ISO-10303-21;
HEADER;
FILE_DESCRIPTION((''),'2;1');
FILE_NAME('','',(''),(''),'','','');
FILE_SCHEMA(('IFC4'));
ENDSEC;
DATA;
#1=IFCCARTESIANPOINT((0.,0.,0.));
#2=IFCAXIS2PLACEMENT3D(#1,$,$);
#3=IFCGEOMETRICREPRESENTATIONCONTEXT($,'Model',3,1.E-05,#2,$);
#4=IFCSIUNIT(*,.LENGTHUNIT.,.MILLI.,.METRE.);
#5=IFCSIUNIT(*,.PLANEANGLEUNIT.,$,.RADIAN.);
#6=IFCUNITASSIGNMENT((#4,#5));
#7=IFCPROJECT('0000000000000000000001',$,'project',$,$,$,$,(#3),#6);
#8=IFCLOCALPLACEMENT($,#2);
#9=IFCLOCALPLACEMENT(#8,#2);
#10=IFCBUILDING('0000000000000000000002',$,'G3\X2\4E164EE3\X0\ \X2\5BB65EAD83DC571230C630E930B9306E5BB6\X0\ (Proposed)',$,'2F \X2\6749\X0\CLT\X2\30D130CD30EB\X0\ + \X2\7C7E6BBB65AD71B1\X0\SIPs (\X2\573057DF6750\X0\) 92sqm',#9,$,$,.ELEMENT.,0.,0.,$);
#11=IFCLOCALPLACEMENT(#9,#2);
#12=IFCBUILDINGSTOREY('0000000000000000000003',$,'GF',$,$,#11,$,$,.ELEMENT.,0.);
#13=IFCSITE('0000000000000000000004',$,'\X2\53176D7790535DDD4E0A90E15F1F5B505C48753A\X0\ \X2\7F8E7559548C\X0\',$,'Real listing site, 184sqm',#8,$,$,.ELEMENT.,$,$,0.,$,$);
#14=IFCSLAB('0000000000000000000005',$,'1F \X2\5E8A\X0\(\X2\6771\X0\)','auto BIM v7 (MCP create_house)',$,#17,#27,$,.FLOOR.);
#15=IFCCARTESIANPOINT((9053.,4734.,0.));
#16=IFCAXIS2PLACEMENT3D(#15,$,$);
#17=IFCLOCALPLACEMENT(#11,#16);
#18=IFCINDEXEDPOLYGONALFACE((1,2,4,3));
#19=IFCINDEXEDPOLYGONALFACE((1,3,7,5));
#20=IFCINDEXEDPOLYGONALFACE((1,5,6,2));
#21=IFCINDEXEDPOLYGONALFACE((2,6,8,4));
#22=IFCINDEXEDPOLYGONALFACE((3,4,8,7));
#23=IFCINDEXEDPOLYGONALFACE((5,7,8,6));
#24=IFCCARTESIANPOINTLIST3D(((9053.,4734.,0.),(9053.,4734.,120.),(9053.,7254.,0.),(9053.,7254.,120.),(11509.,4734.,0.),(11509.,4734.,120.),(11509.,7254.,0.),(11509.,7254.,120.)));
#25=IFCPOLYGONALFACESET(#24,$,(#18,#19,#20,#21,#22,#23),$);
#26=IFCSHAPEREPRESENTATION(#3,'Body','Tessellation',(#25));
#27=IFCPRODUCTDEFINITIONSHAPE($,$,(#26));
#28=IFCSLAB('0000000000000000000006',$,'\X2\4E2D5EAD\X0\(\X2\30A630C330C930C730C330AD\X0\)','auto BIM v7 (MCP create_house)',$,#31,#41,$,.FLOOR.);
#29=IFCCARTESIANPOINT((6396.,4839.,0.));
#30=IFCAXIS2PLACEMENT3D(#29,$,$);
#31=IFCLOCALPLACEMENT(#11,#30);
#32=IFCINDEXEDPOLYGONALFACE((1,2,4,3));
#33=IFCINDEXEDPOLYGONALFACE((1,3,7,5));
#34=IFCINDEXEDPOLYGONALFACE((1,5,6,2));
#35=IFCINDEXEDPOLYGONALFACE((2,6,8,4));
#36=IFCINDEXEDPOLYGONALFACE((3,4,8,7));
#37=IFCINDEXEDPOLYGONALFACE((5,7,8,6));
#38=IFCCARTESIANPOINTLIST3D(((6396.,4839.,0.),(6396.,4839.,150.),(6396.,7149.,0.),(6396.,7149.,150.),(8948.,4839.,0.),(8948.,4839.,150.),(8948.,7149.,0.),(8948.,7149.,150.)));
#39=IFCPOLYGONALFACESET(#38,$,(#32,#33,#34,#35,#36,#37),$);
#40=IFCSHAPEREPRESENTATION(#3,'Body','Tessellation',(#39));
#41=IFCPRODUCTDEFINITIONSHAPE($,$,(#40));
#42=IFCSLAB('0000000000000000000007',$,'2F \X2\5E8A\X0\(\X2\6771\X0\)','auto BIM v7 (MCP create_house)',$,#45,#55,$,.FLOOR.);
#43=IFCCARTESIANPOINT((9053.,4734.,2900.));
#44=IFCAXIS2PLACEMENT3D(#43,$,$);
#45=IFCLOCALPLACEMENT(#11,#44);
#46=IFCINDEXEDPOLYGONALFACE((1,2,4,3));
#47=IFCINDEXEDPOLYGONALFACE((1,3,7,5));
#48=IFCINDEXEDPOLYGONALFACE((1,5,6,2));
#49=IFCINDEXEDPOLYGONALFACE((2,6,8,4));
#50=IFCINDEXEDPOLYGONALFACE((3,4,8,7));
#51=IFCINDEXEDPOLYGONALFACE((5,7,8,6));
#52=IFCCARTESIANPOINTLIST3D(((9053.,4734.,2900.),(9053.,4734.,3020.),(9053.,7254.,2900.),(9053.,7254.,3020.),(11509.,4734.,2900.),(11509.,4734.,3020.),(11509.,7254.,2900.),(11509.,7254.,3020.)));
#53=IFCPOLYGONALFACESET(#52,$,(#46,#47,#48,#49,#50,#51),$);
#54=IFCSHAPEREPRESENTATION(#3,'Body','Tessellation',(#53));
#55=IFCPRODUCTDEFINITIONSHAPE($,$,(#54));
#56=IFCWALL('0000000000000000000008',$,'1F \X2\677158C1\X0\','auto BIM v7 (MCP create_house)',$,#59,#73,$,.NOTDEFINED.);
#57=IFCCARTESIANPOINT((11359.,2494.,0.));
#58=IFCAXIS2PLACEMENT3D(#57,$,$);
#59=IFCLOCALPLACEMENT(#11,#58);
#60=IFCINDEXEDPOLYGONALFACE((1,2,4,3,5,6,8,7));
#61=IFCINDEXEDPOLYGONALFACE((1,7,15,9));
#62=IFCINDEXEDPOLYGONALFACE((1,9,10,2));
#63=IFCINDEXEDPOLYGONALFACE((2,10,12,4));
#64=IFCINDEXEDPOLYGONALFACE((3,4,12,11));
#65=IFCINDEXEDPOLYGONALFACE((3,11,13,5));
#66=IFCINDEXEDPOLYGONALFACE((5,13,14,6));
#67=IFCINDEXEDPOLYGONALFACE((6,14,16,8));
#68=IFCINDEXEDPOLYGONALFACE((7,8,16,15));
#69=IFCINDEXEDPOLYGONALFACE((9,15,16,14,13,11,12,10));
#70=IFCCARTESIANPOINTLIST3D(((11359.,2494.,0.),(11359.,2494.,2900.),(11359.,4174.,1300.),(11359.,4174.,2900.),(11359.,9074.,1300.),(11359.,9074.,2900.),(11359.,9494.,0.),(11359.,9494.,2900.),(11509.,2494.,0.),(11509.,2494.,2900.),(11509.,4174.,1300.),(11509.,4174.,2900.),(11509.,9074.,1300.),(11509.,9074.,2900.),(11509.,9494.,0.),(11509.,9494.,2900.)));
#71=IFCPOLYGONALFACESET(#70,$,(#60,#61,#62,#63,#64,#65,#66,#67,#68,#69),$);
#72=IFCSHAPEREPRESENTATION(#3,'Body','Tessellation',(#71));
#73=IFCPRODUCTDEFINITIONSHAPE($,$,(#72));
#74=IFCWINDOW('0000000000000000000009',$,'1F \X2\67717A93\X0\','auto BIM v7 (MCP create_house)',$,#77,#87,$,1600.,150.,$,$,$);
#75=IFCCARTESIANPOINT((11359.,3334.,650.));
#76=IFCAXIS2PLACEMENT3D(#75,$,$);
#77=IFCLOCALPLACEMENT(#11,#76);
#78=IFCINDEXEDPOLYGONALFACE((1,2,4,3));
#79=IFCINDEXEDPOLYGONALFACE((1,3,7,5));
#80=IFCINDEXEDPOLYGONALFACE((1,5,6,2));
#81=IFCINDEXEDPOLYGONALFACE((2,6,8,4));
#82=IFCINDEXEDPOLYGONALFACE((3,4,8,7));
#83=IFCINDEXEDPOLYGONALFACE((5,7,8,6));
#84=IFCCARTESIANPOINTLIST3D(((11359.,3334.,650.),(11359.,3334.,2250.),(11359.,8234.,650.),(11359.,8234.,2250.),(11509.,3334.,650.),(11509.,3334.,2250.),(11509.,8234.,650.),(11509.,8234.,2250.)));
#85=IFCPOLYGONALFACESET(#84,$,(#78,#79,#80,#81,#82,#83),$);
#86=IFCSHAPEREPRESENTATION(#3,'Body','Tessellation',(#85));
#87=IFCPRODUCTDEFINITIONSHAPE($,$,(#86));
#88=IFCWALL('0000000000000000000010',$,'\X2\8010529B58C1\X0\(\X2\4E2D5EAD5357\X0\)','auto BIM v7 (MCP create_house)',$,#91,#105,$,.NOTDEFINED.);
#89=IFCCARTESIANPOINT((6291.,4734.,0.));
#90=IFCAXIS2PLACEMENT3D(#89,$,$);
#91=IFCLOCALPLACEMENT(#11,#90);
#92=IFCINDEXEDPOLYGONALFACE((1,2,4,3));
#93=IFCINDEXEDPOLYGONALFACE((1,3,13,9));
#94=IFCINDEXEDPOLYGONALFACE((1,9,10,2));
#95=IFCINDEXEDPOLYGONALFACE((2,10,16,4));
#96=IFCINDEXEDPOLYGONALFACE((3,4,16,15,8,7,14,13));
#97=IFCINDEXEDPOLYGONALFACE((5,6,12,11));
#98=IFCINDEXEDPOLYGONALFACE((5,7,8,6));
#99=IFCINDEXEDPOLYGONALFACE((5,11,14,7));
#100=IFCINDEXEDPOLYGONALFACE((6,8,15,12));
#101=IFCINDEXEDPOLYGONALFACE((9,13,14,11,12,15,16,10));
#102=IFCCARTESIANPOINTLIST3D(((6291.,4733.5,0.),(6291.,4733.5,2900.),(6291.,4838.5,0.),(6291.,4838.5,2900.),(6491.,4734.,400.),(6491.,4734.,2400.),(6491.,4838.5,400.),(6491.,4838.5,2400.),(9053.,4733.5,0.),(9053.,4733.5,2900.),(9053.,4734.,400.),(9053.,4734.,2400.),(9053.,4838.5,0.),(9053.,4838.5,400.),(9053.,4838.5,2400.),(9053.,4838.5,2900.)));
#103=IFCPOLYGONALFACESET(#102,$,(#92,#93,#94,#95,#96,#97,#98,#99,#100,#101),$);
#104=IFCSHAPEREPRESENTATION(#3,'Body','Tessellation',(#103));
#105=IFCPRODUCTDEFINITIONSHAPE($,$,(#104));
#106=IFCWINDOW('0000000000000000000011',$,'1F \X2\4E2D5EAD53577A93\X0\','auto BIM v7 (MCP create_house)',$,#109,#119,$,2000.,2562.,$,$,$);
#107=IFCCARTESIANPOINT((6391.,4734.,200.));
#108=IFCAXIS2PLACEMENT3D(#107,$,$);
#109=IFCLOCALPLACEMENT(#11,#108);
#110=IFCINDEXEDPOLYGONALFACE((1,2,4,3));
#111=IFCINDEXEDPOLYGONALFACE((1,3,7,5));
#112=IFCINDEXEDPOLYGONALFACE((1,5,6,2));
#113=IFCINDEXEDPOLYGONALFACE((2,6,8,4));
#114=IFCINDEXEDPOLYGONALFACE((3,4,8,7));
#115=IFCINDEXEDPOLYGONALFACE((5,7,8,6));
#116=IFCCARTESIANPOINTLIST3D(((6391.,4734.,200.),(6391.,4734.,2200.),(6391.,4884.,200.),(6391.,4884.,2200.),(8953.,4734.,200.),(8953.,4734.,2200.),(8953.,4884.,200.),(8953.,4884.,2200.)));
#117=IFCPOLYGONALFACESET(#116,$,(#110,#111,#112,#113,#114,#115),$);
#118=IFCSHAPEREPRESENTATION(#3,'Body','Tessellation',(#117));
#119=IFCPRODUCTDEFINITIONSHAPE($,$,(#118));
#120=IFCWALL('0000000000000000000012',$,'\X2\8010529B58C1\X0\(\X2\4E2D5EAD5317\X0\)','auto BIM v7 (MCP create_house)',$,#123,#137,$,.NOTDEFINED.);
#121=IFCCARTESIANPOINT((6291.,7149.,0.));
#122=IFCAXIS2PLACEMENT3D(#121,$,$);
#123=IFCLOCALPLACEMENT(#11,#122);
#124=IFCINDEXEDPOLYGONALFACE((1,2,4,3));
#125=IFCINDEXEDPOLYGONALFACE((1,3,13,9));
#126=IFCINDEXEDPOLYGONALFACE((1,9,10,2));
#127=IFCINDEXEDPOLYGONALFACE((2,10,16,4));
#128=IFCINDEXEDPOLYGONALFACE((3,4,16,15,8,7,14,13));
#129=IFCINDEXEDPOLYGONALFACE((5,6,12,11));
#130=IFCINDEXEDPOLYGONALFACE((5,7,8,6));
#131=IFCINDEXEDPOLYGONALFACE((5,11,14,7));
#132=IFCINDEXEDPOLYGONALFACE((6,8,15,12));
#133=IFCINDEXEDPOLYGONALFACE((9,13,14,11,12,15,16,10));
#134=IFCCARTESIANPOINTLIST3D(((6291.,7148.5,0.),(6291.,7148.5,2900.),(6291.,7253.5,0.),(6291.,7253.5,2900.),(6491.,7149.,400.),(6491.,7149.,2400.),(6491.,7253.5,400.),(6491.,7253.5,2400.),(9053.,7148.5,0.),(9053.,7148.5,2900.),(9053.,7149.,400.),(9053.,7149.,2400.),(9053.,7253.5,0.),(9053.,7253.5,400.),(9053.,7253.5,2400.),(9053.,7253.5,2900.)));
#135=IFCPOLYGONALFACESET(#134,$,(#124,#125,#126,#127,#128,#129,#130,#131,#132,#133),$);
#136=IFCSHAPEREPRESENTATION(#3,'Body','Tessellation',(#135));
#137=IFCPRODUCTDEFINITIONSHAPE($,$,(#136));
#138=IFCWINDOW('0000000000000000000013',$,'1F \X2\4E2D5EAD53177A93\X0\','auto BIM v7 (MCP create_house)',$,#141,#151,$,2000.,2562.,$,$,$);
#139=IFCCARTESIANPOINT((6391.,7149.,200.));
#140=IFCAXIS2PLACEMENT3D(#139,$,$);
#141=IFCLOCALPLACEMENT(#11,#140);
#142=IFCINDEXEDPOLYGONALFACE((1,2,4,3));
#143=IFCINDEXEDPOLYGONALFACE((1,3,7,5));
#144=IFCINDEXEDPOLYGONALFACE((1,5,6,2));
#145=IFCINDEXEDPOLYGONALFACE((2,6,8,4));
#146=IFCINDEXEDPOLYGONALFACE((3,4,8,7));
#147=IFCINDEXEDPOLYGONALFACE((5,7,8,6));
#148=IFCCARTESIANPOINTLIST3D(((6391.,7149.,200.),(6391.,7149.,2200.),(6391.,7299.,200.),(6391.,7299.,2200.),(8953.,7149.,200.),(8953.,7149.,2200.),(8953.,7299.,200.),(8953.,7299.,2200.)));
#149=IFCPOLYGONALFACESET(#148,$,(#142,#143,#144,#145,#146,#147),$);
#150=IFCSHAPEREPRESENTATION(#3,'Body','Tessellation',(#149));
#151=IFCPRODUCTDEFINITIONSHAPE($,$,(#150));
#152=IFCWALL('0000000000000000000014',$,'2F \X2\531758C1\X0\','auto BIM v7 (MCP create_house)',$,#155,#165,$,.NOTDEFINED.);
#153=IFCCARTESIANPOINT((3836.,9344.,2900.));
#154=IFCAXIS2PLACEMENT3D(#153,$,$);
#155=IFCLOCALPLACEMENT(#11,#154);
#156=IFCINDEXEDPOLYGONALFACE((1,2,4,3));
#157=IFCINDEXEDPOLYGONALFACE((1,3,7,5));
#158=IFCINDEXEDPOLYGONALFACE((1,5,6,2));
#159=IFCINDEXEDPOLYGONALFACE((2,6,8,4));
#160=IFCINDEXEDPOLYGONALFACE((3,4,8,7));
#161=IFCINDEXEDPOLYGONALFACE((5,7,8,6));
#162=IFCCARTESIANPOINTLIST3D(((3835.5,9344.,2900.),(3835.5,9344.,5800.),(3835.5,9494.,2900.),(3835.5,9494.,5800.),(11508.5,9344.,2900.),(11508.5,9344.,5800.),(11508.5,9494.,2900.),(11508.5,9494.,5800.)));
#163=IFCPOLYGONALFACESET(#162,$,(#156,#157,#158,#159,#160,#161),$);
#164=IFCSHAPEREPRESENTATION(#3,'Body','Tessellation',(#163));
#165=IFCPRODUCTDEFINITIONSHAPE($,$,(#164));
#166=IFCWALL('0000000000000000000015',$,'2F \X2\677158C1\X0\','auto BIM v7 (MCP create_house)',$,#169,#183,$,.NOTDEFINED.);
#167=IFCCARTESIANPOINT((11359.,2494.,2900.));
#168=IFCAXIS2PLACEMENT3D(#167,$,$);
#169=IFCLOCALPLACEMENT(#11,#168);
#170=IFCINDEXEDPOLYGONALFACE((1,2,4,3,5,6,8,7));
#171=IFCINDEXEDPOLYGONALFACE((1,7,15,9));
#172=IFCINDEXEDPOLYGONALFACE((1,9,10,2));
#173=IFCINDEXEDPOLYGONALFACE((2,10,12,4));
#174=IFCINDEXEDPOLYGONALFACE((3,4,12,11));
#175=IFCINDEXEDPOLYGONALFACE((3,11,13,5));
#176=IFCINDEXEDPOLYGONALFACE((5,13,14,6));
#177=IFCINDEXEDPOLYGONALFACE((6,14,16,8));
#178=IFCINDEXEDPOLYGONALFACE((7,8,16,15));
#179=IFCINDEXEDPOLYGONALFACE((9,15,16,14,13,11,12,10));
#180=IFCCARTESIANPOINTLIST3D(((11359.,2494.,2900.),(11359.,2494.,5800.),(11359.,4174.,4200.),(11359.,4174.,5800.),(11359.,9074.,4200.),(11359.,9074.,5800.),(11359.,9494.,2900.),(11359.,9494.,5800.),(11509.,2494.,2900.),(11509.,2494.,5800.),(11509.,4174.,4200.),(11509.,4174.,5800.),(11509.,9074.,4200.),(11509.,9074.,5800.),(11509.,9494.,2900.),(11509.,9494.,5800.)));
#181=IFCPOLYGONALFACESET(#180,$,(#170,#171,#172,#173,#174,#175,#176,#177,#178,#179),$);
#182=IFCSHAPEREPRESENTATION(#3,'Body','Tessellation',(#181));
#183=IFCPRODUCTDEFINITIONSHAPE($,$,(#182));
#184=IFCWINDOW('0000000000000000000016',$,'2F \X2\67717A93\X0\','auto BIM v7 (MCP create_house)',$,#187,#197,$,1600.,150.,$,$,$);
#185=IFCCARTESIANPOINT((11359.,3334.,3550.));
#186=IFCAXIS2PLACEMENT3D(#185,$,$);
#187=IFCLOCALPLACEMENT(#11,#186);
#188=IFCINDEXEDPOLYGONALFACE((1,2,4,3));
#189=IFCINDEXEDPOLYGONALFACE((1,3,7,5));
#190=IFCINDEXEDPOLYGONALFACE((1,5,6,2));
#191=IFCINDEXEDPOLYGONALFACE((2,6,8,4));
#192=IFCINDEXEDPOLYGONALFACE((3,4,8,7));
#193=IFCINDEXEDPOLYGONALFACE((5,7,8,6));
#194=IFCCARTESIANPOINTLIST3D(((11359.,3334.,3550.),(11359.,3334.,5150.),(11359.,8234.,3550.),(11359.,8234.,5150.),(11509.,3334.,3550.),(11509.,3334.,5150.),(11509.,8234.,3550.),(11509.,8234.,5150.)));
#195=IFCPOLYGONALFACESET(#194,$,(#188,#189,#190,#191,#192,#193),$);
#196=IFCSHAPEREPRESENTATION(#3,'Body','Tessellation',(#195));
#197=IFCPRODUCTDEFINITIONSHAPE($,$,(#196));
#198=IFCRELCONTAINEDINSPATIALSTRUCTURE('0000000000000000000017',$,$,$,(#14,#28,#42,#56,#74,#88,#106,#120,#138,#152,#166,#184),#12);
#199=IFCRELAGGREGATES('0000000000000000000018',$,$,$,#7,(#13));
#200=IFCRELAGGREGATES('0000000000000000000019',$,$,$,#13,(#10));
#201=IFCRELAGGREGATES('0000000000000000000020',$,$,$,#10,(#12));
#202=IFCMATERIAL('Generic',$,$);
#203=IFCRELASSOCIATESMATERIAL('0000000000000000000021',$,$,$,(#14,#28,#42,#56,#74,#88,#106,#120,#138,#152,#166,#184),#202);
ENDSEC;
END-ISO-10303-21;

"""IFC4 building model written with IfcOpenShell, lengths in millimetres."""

from ifc_helpers import new_model, si_unit, frame, frame_2d, origin, place, context, project, spatial, rectangle, extrude, material, element, fill, save


model = new_model("IFC4")

# Units and contexts
model_context = context("Model", 3, precision=1e-05, world=origin())
ifc_project = project(units=[si_unit("LENGTHUNIT", "METRE", prefix="MILLI"), si_unit("PLANEANGLEUNIT", "RADIAN")], contexts=[model_context])

# Site, building, storey
site_placement = place(None, origin())
site = spatial("IfcSite", under=ifc_project, at=site_placement, Name="北海道川上郡弟子屈町 美留和", ObjectType="Real listing site, 184sqm", CompositionType="ELEMENT", RefElevation=0.0)
building_placement = place(site_placement, origin())
building = spatial("IfcBuilding", under=site, at=building_placement, Name="G3世代 家庭菜園テラスの家 (Proposed)", ObjectType="2F 杉CLTパネル + 籾殻断熱SIPs (地域材) 92sqm", CompositionType="ELEMENT", ElevationOfRefHeight=0.0, ElevationOfTerrain=0.0)
storey_placement = place(building_placement, origin())
storey = spatial("IfcBuildingStorey", under=building, at=storey_placement, Name="GF", CompositionType="ELEMENT", Elevation=0.0)

# Slabs
ifc_material = material(Name="Generic")
slab_1_placement = place(storey_placement, frame((9053.0, 4734.0, 0.0)))
element("IfcSlab", 1, at=slab_1_placement, inside=storey, material=ifc_material, Name="1F 床(東)", Description="auto BIM v7 (MCP create_house)", PredefinedType="FLOOR", context=model_context, shape_type="SweptSolid", body=[
    extrude(rectangle(XDim=2456.0, YDim=2520.0, at=frame_2d((1228.0, 1260.0))), frame((9053.0, 4734.0, 0.0)), (0.0, 0.0, 1.0), 120.0),
])
slab_2_placement = place(storey_placement, frame((6396.0, 4839.0, 0.0)))
element("IfcSlab", 2, at=slab_2_placement, inside=storey, material=ifc_material, Name="中庭(ウッドデッキ)", Description="auto BIM v7 (MCP create_house)", PredefinedType="FLOOR", context=model_context, shape_type="SweptSolid", body=[
    extrude(rectangle(XDim=2552.0, YDim=2310.0, at=frame_2d((1276.0, 1155.0))), frame((6396.0, 4839.0, 0.0)), (0.0, 0.0, 1.0), 150.0),
])
slab_3_placement = place(storey_placement, frame((9053.0, 4734.0, 2900.0)))
element("IfcSlab", 3, at=slab_3_placement, inside=storey, material=ifc_material, Name="2F 床(東)", Description="auto BIM v7 (MCP create_house)", PredefinedType="FLOOR", context=model_context, shape_type="SweptSolid", body=[
    extrude(rectangle(XDim=2456.0, YDim=2520.0, at=frame_2d((1228.0, 1260.0))), frame((9053.0, 4734.0, 2900.0)), (0.0, 0.0, 1.0), 120.0),
])

# Walls, openings, windows
wall_1_placement = place(storey_placement, frame((11359.0, 2494.0, 0.0)))
wall_1 = element("IfcWall", 4, at=wall_1_placement, inside=storey, material=ifc_material, Name="1F 東壁", Description="auto BIM v7 (MCP create_house)", PredefinedType="NOTDEFINED", context=model_context, shape_type="SweptSolid", body=[
    extrude(rectangle(XDim=150.0, YDim=7000.0, at=frame_2d((75.0, 3500.0))), frame((11359.0, 2494.0, 0.0)), (0.0, 0.0, 1.0), 2900.0),
])
opening_1_placement = place(storey_placement, frame((11359.0, 3334.0, 650.0)))
opening_1 = element("IfcOpeningElement", 5, at=opening_1_placement, cuts=wall_1, PredefinedType="NOTDEFINED", context=model_context, shape_type="SweptSolid", body=[
    extrude(rectangle(XDim=150.0, YDim=4900.0, at=frame_2d((75.0, 2450.0))), frame((11359.0, 3334.0, 650.0)), (0.0, 0.0, 1.0), 1600.0),
])
window_1_placement = place(storey_placement, frame((11359.0, 3334.0, 650.0)))
window_1 = element("IfcWindow", 6, at=window_1_placement, inside=storey, material=ifc_material, Name="1F 東窓", Description="auto BIM v7 (MCP create_house)", OverallHeight=1600.0, OverallWidth=150.0, context=model_context, shape_type="SweptSolid", body=[
    extrude(rectangle(XDim=150.0, YDim=4900.0, at=frame_2d((75.0, 2450.0))), frame((11359.0, 3334.0, 650.0)), (0.0, 0.0, 1.0), 1600.0),
])
fill(opening_1, window_1)
wall_2_placement = place(storey_placement, frame((6291.0, 4734.0, 0.0)))
wall_2 = element("IfcWall", 7, at=wall_2_placement, inside=storey, material=ifc_material, Name="耐力壁(中庭南)", Description="auto BIM v7 (MCP create_house)", PredefinedType="NOTDEFINED", context=model_context, shape_type="SweptSolid", body=[
    extrude(rectangle(XDim=2762.0, YDim=105.0, at=frame_2d((1381.0, 52.0))), frame((6291.0, 4734.0, 0.0)), (0.0, 0.0, 1.0), 2900.0),
])
opening_2_placement = place(storey_placement, frame((6391.0, 4734.0, 200.0)))
opening_2 = element("IfcOpeningElement", 8, at=opening_2_placement, cuts=wall_2, PredefinedType="NOTDEFINED", context=model_context, shape_type="SweptSolid", body=[
    extrude(rectangle(XDim=2562.0, YDim=150.0, at=frame_2d((1281.0, 75.0))), frame((6391.0, 4734.0, 200.0)), (0.0, 0.0, 1.0), 2000.0),
])
window_2_placement = place(storey_placement, frame((6391.0, 4734.0, 200.0)))
window_2 = element("IfcWindow", 9, at=window_2_placement, inside=storey, material=ifc_material, Name="1F 中庭南窓", Description="auto BIM v7 (MCP create_house)", OverallHeight=2000.0, OverallWidth=2562.0, context=model_context, shape_type="SweptSolid", body=[
    extrude(rectangle(XDim=2562.0, YDim=150.0, at=frame_2d((1281.0, 75.0))), frame((6391.0, 4734.0, 200.0)), (0.0, 0.0, 1.0), 2000.0),
])
fill(opening_2, window_2)
wall_3_placement = place(storey_placement, frame((6291.0, 7149.0, 0.0)))
wall_3 = element("IfcWall", 10, at=wall_3_placement, inside=storey, material=ifc_material, Name="耐力壁(中庭北)", Description="auto BIM v7 (MCP create_house)", PredefinedType="NOTDEFINED", context=model_context, shape_type="SweptSolid", body=[
    extrude(rectangle(XDim=2762.0, YDim=105.0, at=frame_2d((1381.0, 52.0))), frame((6291.0, 7149.0, 0.0)), (0.0, 0.0, 1.0), 2900.0),
])
opening_3_placement = place(storey_placement, frame((6391.0, 7149.0, 200.0)))
opening_3 = element("IfcOpeningElement", 11, at=opening_3_placement, cuts=wall_3, PredefinedType="NOTDEFINED", context=model_context, shape_type="SweptSolid", body=[
    extrude(rectangle(XDim=2562.0, YDim=150.0, at=frame_2d((1281.0, 75.0))), frame((6391.0, 7149.0, 200.0)), (0.0, 0.0, 1.0), 2000.0),
])
window_3_placement = place(storey_placement, frame((6391.0, 7149.0, 200.0)))
window_3 = element("IfcWindow", 12, at=window_3_placement, inside=storey, material=ifc_material, Name="1F 中庭北窓", Description="auto BIM v7 (MCP create_house)", OverallHeight=2000.0, OverallWidth=2562.0, context=model_context, shape_type="SweptSolid", body=[
    extrude(rectangle(XDim=2562.0, YDim=150.0, at=frame_2d((1281.0, 75.0))), frame((6391.0, 7149.0, 200.0)), (0.0, 0.0, 1.0), 2000.0),
])
fill(opening_3, window_3)

# Wall
wall_4_placement = place(storey_placement, frame((3836.0, 9344.0, 2900.0)))
element("IfcWall", 13, at=wall_4_placement, inside=storey, material=ifc_material, Name="2F 北壁", Description="auto BIM v7 (MCP create_house)", PredefinedType="NOTDEFINED", context=model_context, shape_type="SweptSolid", body=[
    extrude(rectangle(XDim=7673.0, YDim=150.0, at=frame_2d((3836.0, 75.0))), frame((3836.0, 9344.0, 2900.0)), (0.0, 0.0, 1.0), 2900.0),
])

# Wall, opening, window
wall_5_placement = place(storey_placement, frame((11359.0, 2494.0, 2900.0)))
wall_5 = element("IfcWall", 14, at=wall_5_placement, inside=storey, material=ifc_material, Name="2F 東壁", Description="auto BIM v7 (MCP create_house)", PredefinedType="NOTDEFINED", context=model_context, shape_type="SweptSolid", body=[
    extrude(rectangle(XDim=150.0, YDim=7000.0, at=frame_2d((75.0, 3500.0))), frame((11359.0, 2494.0, 2900.0)), (0.0, 0.0, 1.0), 2900.0),
])
opening_4_placement = place(storey_placement, frame((11359.0, 3334.0, 3550.0)))
opening_4 = element("IfcOpeningElement", 15, at=opening_4_placement, cuts=wall_5, PredefinedType="NOTDEFINED", context=model_context, shape_type="SweptSolid", body=[
    extrude(rectangle(XDim=150.0, YDim=4900.0, at=frame_2d((75.0, 2450.0))), frame((11359.0, 3334.0, 3550.0)), (0.0, 0.0, 1.0), 1600.0),
])
window_4_placement = place(storey_placement, frame((11359.0, 3334.0, 3550.0)))
window_4 = element("IfcWindow", 16, at=window_4_placement, inside=storey, material=ifc_material, Name="2F 東窓", Description="auto BIM v7 (MCP create_house)", OverallHeight=1600.0, OverallWidth=150.0, context=model_context, shape_type="SweptSolid", body=[
    extrude(rectangle(XDim=150.0, YDim=4900.0, at=frame_2d((75.0, 2450.0))), frame((11359.0, 3334.0, 3550.0)), (0.0, 0.0, 1.0), 1600.0),
])
fill(opening_4, window_4)

save(model, "model.ifc")
